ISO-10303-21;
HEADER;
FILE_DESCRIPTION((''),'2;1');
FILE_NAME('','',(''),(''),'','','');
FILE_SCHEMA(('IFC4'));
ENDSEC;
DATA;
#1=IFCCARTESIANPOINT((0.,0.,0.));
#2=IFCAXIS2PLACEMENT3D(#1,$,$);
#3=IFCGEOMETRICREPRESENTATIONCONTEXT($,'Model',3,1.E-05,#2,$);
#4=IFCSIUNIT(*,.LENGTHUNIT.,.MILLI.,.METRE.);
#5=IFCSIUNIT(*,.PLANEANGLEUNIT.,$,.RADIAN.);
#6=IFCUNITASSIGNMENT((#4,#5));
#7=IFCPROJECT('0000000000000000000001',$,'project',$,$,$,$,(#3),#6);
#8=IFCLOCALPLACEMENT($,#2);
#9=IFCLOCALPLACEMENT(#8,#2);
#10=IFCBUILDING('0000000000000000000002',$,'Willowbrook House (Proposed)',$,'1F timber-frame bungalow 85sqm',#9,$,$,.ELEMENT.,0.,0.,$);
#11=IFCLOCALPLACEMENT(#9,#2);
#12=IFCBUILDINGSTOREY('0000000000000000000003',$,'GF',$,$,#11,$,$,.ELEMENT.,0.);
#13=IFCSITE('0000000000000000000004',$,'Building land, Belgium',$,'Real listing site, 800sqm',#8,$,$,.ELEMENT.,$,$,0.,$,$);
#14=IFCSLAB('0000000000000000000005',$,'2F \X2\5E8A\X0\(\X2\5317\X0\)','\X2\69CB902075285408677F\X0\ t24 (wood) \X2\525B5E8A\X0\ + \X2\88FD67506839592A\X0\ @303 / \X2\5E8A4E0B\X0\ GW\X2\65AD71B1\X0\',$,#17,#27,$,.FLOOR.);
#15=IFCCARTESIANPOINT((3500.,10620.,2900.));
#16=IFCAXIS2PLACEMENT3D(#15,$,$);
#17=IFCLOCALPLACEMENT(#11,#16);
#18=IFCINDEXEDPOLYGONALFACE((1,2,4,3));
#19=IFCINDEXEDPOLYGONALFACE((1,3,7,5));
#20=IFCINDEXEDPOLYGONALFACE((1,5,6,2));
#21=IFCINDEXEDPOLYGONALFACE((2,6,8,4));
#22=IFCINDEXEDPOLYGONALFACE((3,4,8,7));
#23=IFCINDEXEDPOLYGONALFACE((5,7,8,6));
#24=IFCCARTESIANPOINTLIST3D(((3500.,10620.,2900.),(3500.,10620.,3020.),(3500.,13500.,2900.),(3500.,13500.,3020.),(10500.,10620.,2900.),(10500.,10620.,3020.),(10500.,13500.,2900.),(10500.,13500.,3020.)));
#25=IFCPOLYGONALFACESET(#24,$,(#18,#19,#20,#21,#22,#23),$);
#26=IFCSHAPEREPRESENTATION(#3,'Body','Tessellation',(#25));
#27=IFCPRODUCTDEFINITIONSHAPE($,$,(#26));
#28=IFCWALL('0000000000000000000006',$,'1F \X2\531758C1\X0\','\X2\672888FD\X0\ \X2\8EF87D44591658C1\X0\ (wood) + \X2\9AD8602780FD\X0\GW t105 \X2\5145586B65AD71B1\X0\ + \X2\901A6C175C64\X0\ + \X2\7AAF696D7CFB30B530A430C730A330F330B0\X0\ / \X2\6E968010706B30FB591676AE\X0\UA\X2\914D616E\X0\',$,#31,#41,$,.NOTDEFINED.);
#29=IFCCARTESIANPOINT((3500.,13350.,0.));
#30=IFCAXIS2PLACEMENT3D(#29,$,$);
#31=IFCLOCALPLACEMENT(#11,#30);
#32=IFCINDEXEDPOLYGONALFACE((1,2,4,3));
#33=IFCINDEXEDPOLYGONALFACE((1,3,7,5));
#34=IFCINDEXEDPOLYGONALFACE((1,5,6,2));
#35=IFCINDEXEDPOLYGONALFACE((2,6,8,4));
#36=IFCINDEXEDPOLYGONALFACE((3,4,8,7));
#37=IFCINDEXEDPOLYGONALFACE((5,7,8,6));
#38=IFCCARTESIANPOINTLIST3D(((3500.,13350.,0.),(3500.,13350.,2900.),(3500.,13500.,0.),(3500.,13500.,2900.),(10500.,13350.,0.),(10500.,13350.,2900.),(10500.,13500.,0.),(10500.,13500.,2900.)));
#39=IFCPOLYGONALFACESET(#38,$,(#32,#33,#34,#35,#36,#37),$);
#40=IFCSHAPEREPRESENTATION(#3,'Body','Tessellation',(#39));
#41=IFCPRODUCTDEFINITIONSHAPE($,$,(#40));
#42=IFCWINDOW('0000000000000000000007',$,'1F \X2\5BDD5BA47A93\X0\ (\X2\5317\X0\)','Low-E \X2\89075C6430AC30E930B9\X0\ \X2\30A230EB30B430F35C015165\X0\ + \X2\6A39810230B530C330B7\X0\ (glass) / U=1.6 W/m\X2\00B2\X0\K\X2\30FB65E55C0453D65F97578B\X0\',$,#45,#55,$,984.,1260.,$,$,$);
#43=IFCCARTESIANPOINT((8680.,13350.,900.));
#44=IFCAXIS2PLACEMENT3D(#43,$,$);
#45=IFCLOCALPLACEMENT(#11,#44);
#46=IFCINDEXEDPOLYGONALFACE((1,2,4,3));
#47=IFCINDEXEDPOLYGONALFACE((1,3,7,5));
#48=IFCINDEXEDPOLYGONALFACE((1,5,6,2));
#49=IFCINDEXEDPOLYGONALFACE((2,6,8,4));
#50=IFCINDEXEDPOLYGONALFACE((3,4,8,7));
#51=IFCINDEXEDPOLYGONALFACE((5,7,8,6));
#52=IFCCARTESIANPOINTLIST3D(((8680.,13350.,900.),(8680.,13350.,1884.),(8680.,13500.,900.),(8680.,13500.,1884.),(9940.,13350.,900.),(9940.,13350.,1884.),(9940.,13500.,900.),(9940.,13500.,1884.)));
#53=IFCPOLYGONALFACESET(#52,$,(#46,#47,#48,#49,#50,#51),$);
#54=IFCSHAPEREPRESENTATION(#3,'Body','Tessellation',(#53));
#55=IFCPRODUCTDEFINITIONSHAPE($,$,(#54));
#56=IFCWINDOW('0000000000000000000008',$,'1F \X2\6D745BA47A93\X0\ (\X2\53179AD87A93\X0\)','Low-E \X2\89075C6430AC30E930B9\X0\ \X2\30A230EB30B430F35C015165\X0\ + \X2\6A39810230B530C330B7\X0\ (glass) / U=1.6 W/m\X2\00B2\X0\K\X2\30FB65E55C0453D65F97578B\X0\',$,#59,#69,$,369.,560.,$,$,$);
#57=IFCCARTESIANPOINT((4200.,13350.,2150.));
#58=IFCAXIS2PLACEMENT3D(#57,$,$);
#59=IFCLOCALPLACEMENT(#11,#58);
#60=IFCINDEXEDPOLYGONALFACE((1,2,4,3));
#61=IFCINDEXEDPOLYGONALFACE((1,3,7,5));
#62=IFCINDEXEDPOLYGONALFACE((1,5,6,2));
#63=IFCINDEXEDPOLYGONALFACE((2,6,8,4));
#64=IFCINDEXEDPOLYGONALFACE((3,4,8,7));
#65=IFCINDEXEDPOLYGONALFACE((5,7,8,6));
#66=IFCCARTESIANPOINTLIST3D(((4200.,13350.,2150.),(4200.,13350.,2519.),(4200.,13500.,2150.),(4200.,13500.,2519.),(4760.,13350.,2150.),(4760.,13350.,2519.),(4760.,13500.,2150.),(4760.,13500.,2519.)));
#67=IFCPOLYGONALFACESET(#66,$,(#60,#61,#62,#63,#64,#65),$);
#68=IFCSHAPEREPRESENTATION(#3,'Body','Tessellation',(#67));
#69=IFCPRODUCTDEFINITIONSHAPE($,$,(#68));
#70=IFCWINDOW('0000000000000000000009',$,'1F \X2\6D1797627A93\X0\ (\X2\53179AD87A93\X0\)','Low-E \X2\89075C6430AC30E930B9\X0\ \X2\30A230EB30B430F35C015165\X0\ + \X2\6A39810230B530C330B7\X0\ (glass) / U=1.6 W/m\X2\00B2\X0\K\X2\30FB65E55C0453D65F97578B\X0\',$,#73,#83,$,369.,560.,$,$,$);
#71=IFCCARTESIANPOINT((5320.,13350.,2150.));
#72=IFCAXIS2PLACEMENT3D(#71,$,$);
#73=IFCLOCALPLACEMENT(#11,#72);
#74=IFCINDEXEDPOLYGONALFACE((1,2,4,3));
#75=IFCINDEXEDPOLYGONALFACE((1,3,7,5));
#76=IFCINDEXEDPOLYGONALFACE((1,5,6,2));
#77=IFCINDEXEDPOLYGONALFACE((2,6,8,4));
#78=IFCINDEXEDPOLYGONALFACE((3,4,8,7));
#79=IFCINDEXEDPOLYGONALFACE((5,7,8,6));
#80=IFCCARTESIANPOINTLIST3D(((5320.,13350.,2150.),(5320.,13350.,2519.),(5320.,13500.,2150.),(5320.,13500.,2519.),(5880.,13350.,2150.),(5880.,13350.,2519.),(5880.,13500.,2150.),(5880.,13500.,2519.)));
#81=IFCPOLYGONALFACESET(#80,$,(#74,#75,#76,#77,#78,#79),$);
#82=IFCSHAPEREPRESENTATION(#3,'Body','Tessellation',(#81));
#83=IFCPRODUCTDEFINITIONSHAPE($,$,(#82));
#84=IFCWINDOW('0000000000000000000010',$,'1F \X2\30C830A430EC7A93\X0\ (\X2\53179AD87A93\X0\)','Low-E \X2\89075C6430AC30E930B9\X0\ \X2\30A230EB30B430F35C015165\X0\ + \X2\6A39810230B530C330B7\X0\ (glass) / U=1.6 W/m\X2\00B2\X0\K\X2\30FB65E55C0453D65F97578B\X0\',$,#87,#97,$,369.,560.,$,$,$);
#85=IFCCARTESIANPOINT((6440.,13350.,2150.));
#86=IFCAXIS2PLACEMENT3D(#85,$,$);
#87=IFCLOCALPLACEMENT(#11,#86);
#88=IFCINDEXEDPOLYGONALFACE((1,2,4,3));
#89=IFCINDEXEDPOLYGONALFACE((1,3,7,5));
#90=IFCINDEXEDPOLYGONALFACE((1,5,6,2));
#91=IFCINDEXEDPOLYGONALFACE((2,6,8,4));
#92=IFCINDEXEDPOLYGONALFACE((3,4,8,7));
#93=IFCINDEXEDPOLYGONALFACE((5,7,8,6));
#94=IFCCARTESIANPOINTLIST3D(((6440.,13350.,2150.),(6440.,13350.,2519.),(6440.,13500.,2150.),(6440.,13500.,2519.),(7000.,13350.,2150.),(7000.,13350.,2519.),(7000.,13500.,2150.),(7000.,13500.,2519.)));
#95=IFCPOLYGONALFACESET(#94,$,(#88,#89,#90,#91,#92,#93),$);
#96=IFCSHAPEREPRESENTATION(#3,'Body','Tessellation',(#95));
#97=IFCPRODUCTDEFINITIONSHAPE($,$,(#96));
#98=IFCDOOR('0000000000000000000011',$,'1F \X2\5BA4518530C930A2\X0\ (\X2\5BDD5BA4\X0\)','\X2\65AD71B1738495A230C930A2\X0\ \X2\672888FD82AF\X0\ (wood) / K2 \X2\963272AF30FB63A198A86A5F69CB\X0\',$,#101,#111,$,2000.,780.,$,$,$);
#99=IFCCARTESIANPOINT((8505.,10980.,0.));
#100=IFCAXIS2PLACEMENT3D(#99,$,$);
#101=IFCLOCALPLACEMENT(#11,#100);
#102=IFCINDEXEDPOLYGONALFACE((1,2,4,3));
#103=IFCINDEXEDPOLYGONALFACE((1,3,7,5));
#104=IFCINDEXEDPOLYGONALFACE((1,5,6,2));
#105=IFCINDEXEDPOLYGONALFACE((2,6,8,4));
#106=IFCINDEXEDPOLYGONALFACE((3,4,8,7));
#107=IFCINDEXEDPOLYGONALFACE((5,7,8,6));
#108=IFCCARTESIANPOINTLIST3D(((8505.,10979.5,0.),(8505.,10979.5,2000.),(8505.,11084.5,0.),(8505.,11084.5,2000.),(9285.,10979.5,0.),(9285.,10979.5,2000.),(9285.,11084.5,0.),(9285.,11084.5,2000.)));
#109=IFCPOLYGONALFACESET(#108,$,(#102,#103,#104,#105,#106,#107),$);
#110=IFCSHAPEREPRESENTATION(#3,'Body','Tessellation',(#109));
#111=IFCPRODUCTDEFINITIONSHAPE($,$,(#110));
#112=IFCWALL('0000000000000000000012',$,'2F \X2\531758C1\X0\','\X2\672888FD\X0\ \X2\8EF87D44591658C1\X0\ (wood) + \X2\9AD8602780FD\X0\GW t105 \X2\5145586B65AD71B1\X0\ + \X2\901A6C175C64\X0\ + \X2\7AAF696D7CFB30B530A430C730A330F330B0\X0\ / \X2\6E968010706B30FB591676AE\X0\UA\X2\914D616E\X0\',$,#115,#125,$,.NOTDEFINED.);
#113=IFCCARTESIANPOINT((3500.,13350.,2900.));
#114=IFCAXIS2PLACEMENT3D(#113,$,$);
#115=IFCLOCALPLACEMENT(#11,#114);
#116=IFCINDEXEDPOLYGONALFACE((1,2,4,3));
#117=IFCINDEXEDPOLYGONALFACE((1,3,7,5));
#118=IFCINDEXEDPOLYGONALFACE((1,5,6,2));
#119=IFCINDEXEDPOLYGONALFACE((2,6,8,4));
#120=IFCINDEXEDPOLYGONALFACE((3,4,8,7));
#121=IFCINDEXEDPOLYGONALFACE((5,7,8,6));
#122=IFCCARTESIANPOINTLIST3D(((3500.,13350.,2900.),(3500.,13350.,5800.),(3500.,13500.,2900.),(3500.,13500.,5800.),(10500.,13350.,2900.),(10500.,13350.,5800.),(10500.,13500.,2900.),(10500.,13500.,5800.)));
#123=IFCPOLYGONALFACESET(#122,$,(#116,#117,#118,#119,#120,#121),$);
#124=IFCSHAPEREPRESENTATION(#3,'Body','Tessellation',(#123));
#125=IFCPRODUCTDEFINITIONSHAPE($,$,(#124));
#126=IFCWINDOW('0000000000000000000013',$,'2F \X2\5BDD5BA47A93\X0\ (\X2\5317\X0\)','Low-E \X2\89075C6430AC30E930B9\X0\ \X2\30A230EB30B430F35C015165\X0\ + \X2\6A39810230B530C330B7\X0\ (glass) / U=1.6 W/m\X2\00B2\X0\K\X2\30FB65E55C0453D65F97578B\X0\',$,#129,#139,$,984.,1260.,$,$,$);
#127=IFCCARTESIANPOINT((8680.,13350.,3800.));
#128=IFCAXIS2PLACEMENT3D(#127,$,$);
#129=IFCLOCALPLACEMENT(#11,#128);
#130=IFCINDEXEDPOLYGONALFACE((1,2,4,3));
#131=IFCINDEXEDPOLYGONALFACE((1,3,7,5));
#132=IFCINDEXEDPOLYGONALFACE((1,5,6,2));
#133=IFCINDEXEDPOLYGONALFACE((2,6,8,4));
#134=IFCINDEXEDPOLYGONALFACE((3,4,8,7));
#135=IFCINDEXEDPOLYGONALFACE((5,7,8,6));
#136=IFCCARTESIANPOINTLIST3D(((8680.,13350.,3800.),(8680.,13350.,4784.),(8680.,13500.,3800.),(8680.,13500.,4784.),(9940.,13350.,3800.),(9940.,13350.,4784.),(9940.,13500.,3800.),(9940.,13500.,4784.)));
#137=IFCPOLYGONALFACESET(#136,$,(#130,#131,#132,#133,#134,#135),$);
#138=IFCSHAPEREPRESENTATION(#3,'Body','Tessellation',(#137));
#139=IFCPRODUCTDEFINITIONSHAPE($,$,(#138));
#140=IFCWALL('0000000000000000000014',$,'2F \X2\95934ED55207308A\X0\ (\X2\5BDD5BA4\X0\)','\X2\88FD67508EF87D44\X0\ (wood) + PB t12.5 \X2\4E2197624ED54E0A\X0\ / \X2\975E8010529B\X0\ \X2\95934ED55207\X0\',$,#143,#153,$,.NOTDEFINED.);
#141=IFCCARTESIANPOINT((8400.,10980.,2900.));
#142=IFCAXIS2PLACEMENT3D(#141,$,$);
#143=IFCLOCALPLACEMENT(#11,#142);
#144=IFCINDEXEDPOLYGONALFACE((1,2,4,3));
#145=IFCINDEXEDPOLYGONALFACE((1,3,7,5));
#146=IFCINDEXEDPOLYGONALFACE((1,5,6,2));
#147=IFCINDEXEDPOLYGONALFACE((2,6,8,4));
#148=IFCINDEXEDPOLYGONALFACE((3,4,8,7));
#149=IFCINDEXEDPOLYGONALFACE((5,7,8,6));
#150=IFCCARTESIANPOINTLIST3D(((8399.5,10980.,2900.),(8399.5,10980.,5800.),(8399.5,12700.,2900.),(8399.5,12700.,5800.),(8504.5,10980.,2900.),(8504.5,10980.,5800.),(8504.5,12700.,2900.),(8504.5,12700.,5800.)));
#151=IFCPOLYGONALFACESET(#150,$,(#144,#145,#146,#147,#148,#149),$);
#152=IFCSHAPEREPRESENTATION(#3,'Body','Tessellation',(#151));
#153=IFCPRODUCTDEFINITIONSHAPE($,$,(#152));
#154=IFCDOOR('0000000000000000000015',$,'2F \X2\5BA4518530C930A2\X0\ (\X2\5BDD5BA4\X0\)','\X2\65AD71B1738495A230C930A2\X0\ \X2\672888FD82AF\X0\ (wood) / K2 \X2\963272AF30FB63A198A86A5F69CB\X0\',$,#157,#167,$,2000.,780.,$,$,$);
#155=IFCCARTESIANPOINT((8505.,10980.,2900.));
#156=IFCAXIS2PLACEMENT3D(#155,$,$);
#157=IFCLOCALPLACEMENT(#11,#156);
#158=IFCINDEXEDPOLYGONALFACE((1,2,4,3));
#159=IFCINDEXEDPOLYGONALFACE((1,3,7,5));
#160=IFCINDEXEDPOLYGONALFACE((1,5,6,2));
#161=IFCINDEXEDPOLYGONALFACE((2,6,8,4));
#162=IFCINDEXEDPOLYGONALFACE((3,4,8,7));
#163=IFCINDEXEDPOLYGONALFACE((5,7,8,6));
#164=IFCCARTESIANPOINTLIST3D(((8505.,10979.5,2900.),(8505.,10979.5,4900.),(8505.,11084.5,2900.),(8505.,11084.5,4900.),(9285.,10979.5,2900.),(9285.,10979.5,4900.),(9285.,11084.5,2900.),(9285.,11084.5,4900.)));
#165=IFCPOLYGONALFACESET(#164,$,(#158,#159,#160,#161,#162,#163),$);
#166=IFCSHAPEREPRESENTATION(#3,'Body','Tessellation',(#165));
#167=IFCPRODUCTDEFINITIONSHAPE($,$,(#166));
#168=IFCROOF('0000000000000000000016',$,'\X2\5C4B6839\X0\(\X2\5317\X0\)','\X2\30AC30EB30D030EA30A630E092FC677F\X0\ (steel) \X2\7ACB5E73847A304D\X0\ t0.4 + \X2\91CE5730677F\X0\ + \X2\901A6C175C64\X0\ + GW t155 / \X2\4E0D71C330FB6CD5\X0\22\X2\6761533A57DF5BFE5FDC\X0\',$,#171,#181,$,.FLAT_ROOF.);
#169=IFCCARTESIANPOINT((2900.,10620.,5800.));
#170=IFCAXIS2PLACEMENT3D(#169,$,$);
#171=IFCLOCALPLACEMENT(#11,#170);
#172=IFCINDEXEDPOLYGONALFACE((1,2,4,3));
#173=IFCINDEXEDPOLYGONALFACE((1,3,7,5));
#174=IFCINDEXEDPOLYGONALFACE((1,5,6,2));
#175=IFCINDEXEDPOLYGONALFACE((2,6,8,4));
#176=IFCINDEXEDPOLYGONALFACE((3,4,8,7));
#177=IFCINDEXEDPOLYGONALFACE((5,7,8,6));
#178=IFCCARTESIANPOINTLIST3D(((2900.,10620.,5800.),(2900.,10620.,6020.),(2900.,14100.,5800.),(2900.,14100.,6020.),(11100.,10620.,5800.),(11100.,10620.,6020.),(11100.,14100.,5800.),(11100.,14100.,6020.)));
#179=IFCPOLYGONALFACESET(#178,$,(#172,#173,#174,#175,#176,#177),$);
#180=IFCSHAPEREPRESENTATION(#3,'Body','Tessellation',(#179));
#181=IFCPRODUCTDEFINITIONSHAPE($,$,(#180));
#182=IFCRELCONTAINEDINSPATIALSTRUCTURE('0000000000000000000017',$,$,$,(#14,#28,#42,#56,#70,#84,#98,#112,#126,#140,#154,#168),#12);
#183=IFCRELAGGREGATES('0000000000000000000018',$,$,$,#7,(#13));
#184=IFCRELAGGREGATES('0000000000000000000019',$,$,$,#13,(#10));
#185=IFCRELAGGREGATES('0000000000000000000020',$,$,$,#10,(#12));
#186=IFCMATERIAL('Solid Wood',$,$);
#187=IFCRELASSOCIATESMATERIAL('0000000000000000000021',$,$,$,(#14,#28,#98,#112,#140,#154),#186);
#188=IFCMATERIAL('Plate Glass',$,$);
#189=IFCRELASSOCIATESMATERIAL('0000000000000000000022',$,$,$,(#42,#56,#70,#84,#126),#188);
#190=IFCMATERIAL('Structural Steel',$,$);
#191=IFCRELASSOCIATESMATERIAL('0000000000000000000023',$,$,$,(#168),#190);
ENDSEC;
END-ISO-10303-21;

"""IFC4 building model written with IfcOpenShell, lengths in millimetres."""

from ifc_helpers import new_model, si_unit, frame, frame_2d, origin, place, context, project, spatial, rectangle, extrude, material, element, fill, save


model = new_model("IFC4")

# Units and contexts
model_context = context("Model", 3, precision=1e-05, world=origin())
ifc_project = project(units=[si_unit("LENGTHUNIT", "METRE", prefix="MILLI"), si_unit("PLANEANGLEUNIT", "RADIAN")], contexts=[model_context])

# Site, building, storey
site_placement = place(None, origin())
site = spatial("IfcSite", under=ifc_project, at=site_placement, Name="Building land, Belgium", ObjectType="Real listing site, 800sqm", CompositionType="ELEMENT", RefElevation=0.0)
building_placement = place(site_placement, origin())
building = spatial("IfcBuilding", under=site, at=building_placement, Name="Willowbrook House (Proposed)", ObjectType="1F timber-frame bungalow 85sqm", CompositionType="ELEMENT", ElevationOfRefHeight=0.0, ElevationOfTerrain=0.0)
storey_placement = place(building_placement, origin())
storey = spatial("IfcBuildingStorey", under=building, at=storey_placement, Name="GF", CompositionType="ELEMENT", Elevation=0.0)

# Slab
ifc_material_1 = material(Name="Solid Wood")
slab_placement = place(storey_placement, frame((3500.0, 10620.0, 2900.0)))
element("IfcSlab", 1, at=slab_placement, inside=storey, material=ifc_material_1, Name="2F 床(北)", Description="構造用合板 t24 (wood) 剛床 + 製材根太 @303 / 床下 GW断熱", PredefinedType="FLOOR", context=model_context, shape_type="SweptSolid", body=[
    extrude(rectangle(XDim=7000.0, YDim=2880.0, at=frame_2d((3500.0, 1440.0))), frame((3500.0, 10620.0, 2900.0)), (0.0, 0.0, 1.0), 120.0),
])

# Wall, openings, windows
wall_1_placement = place(storey_placement, frame((3500.0, 13350.0, 0.0)))
wall_1 = element("IfcWall", 2, at=wall_1_placement, inside=storey, material=ifc_material_1, Name="1F 北壁", Description="木製 軸組外壁 (wood) + 高性能GW t105 充填断熱 + 通気層 + 窯業系サイディング / 準耐火・外皮UA配慮", PredefinedType="NOTDEFINED", context=model_context, shape_type="SweptSolid", body=[
    extrude(rectangle(XDim=7000.0, YDim=150.0, at=frame_2d((3500.0, 75.0))), frame((3500.0, 13350.0, 0.0)), (0.0, 0.0, 1.0), 2900.0),
])
opening_1_placement = place(storey_placement, frame((8680.0, 13350.0, 900.0)))
opening_1 = element("IfcOpeningElement", 3, at=opening_1_placement, cuts=wall_1, PredefinedType="NOTDEFINED", context=model_context, shape_type="SweptSolid", body=[
    extrude(rectangle(XDim=1260.0, YDim=150.0, at=frame_2d((630.0, 75.0))), frame((8680.0, 13350.0, 900.0)), (0.0, 0.0, 1.0), 984.0),
])
opening_2_placement = place(storey_placement, frame((4200.0, 13350.0, 2150.0)))
opening_2 = element("IfcOpeningElement", 4, at=opening_2_placement, cuts=wall_1, PredefinedType="NOTDEFINED", context=model_context, shape_type="SweptSolid", body=[
    extrude(rectangle(XDim=560.0, YDim=150.0, at=frame_2d((280.0, 75.0))), frame((4200.0, 13350.0, 2150.0)), (0.0, 0.0, 1.0), 369.0),
])
opening_3_placement = place(storey_placement, frame((5320.0, 13350.0, 2150.0)))
opening_3 = element("IfcOpeningElement", 5, at=opening_3_placement, cuts=wall_1, PredefinedType="NOTDEFINED", context=model_context, shape_type="SweptSolid", body=[
    extrude(rectangle(XDim=560.0, YDim=150.0, at=frame_2d((280.0, 75.0))), frame((5320.0, 13350.0, 2150.0)), (0.0, 0.0, 1.0), 369.0),
])
opening_4_placement = place(storey_placement, frame((6440.0, 13350.0, 2150.0)))
opening_4 = element("IfcOpeningElement", 6, at=opening_4_placement, cuts=wall_1, PredefinedType="NOTDEFINED", context=model_context, shape_type="SweptSolid", body=[
    extrude(rectangle(XDim=560.0, YDim=150.0, at=frame_2d((280.0, 75.0))), frame((6440.0, 13350.0, 2150.0)), (0.0, 0.0, 1.0), 369.0),
])
ifc_material_2 = material(Name="Plate Glass")
window_1_placement = place(storey_placement, frame((8680.0, 13350.0, 900.0)))
window_1 = element("IfcWindow", 7, at=window_1_placement, inside=storey, material=ifc_material_2, Name="1F 寝室窓 (北)", Description="Low-E 複層ガラス アルゴン封入 + 樹脂サッシ (glass) / U=1.6 W/m²K・日射取得型", OverallHeight=984.0, OverallWidth=1260.0, context=model_context, shape_type="SweptSolid", body=[
    extrude(rectangle(XDim=1260.0, YDim=150.0, at=frame_2d((630.0, 75.0))), frame((8680.0, 13350.0, 900.0)), (0.0, 0.0, 1.0), 984.0),
])
fill(opening_1, window_1)
window_2_placement = place(storey_placement, frame((4200.0, 13350.0, 2150.0)))
window_2 = element("IfcWindow", 8, at=window_2_placement, inside=storey, material=ifc_material_2, Name="1F 浴室窓 (北高窓)", Description="Low-E 複層ガラス アルゴン封入 + 樹脂サッシ (glass) / U=1.6 W/m²K・日射取得型", OverallHeight=369.0, OverallWidth=560.0, context=model_context, shape_type="SweptSolid", body=[
    extrude(rectangle(XDim=560.0, YDim=150.0, at=frame_2d((280.0, 75.0))), frame((4200.0, 13350.0, 2150.0)), (0.0, 0.0, 1.0), 369.0),
])
fill(opening_2, window_2)
window_3_placement = place(storey_placement, frame((5320.0, 13350.0, 2150.0)))
window_3 = element("IfcWindow", 9, at=window_3_placement, inside=storey, material=ifc_material_2, Name="1F 洗面窓 (北高窓)", Description="Low-E 複層ガラス アルゴン封入 + 樹脂サッシ (glass) / U=1.6 W/m²K・日射取得型", OverallHeight=369.0, OverallWidth=560.0, context=model_context, shape_type="SweptSolid", body=[
    extrude(rectangle(XDim=560.0, YDim=150.0, at=frame_2d((280.0, 75.0))), frame((5320.0, 13350.0, 2150.0)), (0.0, 0.0, 1.0), 369.0),
])
fill(opening_3, window_3)
window_4_placement = place(storey_placement, frame((6440.0, 13350.0, 2150.0)))
window_4 = element("IfcWindow", 10, at=window_4_placement, inside=storey, material=ifc_material_2, Name="1F トイレ窓 (北高窓)", Description="Low-E 複層ガラス アルゴン封入 + 樹脂サッシ (glass) / U=1.6 W/m²K・日射取得型", OverallHeight=369.0, OverallWidth=560.0, context=model_context, shape_type="SweptSolid", body=[
    extrude(rectangle(XDim=560.0, YDim=150.0, at=frame_2d((280.0, 75.0))), frame((6440.0, 13350.0, 2150.0)), (0.0, 0.0, 1.0), 369.0),
])
fill(opening_4, window_4)

# Door
door_1_placement = place(storey_placement, frame((8505.0, 10980.0, 0.0)))
element("IfcDoor", 11, at=door_1_placement, inside=storey, material=ifc_material_1, Name="1F 室内ドア (寝室)", Description="断熱玄関ドア 木製芯 (wood) / K2 防犯・採風機構", OverallHeight=2000.0, OverallWidth=780.0, context=model_context, shape_type="SweptSolid", body=[
    extrude(rectangle(XDim=780.0, YDim=105.0, at=frame_2d((390.0, 52.0))), frame((8505.0, 10980.0, 0.0)), (0.0, 0.0, 1.0), 2000.0),
])

# Wall, opening, window
wall_2_placement = place(storey_placement, frame((3500.0, 13350.0, 2900.0)))
wall_2 = element("IfcWall", 12, at=wall_2_placement, inside=storey, material=ifc_material_1, Name="2F 北壁", Description="木製 軸組外壁 (wood) + 高性能GW t105 充填断熱 + 通気層 + 窯業系サイディング / 準耐火・外皮UA配慮", PredefinedType="NOTDEFINED", context=model_context, shape_type="SweptSolid", body=[
    extrude(rectangle(XDim=7000.0, YDim=150.0, at=frame_2d((3500.0, 75.0))), frame((3500.0, 13350.0, 2900.0)), (0.0, 0.0, 1.0), 2900.0),
])
opening_5_placement = place(storey_placement, frame((8680.0, 13350.0, 3800.0)))
opening_5 = element("IfcOpeningElement", 13, at=opening_5_placement, cuts=wall_2, PredefinedType="NOTDEFINED", context=model_context, shape_type="SweptSolid", body=[
    extrude(rectangle(XDim=1260.0, YDim=150.0, at=frame_2d((630.0, 75.0))), frame((8680.0, 13350.0, 3800.0)), (0.0, 0.0, 1.0), 984.0),
])
window_5_placement = place(storey_placement, frame((8680.0, 13350.0, 3800.0)))
window_5 = element("IfcWindow", 14, at=window_5_placement, inside=storey, material=ifc_material_2, Name="2F 寝室窓 (北)", Description="Low-E 複層ガラス アルゴン封入 + 樹脂サッシ (glass) / U=1.6 W/m²K・日射取得型", OverallHeight=984.0, OverallWidth=1260.0, context=model_context, shape_type="SweptSolid", body=[
    extrude(rectangle(XDim=1260.0, YDim=150.0, at=frame_2d((630.0, 75.0))), frame((8680.0, 13350.0, 3800.0)), (0.0, 0.0, 1.0), 984.0),
])
fill(opening_5, window_5)

# Wall
wall_3_placement = place(storey_placement, frame((8400.0, 10980.0, 2900.0)))
element("IfcWall", 15, at=wall_3_placement, inside=storey, material=ifc_material_1, Name="2F 間仕切り (寝室)", Description="製材軸組 (wood) + PB t12.5 両面仕上 / 非耐力 間仕切", PredefinedType="NOTDEFINED", context=model_context, shape_type="SweptSolid", body=[
    extrude(rectangle(XDim=105.0, YDim=1720.0, at=frame_2d((52.0, 860.0))), frame((8400.0, 10980.0, 2900.0)), (0.0, 0.0, 1.0), 2900.0),
])

# Door
door_2_placement = place(storey_placement, frame((8505.0, 10980.0, 2900.0)))
element("IfcDoor", 16, at=door_2_placement, inside=storey, material=ifc_material_1, Name="2F 室内ドア (寝室)", Description="断熱玄関ドア 木製芯 (wood) / K2 防犯・採風機構", OverallHeight=2000.0, OverallWidth=780.0, context=model_context, shape_type="SweptSolid", body=[
    extrude(rectangle(XDim=780.0, YDim=105.0, at=frame_2d((390.0, 52.0))), frame((8505.0, 10980.0, 2900.0)), (0.0, 0.0, 1.0), 2000.0),
])

# Roof
ifc_material_3 = material(Name="Structural Steel")
roof_placement = place(storey_placement, frame((2900.0, 10620.0, 5800.0)))
element("IfcRoof", 17, at=roof_placement, inside=storey, material=ifc_material_3, Name="屋根(北)", Description="ガルバリウム鋼板 (steel) 立平葺き t0.4 + 野地板 + 通気層 + GW t155 / 不燃・法22条区域対応", PredefinedType="FLAT_ROOF", context=model_context, shape_type="SweptSolid", body=[
    extrude(rectangle(XDim=8200.0, YDim=3480.0, at=frame_2d((4100.0, 1740.0))), frame((2900.0, 10620.0, 5800.0)), (0.0, 0.0, 1.0), 220.0),
])

save(model, "model.ifc")
